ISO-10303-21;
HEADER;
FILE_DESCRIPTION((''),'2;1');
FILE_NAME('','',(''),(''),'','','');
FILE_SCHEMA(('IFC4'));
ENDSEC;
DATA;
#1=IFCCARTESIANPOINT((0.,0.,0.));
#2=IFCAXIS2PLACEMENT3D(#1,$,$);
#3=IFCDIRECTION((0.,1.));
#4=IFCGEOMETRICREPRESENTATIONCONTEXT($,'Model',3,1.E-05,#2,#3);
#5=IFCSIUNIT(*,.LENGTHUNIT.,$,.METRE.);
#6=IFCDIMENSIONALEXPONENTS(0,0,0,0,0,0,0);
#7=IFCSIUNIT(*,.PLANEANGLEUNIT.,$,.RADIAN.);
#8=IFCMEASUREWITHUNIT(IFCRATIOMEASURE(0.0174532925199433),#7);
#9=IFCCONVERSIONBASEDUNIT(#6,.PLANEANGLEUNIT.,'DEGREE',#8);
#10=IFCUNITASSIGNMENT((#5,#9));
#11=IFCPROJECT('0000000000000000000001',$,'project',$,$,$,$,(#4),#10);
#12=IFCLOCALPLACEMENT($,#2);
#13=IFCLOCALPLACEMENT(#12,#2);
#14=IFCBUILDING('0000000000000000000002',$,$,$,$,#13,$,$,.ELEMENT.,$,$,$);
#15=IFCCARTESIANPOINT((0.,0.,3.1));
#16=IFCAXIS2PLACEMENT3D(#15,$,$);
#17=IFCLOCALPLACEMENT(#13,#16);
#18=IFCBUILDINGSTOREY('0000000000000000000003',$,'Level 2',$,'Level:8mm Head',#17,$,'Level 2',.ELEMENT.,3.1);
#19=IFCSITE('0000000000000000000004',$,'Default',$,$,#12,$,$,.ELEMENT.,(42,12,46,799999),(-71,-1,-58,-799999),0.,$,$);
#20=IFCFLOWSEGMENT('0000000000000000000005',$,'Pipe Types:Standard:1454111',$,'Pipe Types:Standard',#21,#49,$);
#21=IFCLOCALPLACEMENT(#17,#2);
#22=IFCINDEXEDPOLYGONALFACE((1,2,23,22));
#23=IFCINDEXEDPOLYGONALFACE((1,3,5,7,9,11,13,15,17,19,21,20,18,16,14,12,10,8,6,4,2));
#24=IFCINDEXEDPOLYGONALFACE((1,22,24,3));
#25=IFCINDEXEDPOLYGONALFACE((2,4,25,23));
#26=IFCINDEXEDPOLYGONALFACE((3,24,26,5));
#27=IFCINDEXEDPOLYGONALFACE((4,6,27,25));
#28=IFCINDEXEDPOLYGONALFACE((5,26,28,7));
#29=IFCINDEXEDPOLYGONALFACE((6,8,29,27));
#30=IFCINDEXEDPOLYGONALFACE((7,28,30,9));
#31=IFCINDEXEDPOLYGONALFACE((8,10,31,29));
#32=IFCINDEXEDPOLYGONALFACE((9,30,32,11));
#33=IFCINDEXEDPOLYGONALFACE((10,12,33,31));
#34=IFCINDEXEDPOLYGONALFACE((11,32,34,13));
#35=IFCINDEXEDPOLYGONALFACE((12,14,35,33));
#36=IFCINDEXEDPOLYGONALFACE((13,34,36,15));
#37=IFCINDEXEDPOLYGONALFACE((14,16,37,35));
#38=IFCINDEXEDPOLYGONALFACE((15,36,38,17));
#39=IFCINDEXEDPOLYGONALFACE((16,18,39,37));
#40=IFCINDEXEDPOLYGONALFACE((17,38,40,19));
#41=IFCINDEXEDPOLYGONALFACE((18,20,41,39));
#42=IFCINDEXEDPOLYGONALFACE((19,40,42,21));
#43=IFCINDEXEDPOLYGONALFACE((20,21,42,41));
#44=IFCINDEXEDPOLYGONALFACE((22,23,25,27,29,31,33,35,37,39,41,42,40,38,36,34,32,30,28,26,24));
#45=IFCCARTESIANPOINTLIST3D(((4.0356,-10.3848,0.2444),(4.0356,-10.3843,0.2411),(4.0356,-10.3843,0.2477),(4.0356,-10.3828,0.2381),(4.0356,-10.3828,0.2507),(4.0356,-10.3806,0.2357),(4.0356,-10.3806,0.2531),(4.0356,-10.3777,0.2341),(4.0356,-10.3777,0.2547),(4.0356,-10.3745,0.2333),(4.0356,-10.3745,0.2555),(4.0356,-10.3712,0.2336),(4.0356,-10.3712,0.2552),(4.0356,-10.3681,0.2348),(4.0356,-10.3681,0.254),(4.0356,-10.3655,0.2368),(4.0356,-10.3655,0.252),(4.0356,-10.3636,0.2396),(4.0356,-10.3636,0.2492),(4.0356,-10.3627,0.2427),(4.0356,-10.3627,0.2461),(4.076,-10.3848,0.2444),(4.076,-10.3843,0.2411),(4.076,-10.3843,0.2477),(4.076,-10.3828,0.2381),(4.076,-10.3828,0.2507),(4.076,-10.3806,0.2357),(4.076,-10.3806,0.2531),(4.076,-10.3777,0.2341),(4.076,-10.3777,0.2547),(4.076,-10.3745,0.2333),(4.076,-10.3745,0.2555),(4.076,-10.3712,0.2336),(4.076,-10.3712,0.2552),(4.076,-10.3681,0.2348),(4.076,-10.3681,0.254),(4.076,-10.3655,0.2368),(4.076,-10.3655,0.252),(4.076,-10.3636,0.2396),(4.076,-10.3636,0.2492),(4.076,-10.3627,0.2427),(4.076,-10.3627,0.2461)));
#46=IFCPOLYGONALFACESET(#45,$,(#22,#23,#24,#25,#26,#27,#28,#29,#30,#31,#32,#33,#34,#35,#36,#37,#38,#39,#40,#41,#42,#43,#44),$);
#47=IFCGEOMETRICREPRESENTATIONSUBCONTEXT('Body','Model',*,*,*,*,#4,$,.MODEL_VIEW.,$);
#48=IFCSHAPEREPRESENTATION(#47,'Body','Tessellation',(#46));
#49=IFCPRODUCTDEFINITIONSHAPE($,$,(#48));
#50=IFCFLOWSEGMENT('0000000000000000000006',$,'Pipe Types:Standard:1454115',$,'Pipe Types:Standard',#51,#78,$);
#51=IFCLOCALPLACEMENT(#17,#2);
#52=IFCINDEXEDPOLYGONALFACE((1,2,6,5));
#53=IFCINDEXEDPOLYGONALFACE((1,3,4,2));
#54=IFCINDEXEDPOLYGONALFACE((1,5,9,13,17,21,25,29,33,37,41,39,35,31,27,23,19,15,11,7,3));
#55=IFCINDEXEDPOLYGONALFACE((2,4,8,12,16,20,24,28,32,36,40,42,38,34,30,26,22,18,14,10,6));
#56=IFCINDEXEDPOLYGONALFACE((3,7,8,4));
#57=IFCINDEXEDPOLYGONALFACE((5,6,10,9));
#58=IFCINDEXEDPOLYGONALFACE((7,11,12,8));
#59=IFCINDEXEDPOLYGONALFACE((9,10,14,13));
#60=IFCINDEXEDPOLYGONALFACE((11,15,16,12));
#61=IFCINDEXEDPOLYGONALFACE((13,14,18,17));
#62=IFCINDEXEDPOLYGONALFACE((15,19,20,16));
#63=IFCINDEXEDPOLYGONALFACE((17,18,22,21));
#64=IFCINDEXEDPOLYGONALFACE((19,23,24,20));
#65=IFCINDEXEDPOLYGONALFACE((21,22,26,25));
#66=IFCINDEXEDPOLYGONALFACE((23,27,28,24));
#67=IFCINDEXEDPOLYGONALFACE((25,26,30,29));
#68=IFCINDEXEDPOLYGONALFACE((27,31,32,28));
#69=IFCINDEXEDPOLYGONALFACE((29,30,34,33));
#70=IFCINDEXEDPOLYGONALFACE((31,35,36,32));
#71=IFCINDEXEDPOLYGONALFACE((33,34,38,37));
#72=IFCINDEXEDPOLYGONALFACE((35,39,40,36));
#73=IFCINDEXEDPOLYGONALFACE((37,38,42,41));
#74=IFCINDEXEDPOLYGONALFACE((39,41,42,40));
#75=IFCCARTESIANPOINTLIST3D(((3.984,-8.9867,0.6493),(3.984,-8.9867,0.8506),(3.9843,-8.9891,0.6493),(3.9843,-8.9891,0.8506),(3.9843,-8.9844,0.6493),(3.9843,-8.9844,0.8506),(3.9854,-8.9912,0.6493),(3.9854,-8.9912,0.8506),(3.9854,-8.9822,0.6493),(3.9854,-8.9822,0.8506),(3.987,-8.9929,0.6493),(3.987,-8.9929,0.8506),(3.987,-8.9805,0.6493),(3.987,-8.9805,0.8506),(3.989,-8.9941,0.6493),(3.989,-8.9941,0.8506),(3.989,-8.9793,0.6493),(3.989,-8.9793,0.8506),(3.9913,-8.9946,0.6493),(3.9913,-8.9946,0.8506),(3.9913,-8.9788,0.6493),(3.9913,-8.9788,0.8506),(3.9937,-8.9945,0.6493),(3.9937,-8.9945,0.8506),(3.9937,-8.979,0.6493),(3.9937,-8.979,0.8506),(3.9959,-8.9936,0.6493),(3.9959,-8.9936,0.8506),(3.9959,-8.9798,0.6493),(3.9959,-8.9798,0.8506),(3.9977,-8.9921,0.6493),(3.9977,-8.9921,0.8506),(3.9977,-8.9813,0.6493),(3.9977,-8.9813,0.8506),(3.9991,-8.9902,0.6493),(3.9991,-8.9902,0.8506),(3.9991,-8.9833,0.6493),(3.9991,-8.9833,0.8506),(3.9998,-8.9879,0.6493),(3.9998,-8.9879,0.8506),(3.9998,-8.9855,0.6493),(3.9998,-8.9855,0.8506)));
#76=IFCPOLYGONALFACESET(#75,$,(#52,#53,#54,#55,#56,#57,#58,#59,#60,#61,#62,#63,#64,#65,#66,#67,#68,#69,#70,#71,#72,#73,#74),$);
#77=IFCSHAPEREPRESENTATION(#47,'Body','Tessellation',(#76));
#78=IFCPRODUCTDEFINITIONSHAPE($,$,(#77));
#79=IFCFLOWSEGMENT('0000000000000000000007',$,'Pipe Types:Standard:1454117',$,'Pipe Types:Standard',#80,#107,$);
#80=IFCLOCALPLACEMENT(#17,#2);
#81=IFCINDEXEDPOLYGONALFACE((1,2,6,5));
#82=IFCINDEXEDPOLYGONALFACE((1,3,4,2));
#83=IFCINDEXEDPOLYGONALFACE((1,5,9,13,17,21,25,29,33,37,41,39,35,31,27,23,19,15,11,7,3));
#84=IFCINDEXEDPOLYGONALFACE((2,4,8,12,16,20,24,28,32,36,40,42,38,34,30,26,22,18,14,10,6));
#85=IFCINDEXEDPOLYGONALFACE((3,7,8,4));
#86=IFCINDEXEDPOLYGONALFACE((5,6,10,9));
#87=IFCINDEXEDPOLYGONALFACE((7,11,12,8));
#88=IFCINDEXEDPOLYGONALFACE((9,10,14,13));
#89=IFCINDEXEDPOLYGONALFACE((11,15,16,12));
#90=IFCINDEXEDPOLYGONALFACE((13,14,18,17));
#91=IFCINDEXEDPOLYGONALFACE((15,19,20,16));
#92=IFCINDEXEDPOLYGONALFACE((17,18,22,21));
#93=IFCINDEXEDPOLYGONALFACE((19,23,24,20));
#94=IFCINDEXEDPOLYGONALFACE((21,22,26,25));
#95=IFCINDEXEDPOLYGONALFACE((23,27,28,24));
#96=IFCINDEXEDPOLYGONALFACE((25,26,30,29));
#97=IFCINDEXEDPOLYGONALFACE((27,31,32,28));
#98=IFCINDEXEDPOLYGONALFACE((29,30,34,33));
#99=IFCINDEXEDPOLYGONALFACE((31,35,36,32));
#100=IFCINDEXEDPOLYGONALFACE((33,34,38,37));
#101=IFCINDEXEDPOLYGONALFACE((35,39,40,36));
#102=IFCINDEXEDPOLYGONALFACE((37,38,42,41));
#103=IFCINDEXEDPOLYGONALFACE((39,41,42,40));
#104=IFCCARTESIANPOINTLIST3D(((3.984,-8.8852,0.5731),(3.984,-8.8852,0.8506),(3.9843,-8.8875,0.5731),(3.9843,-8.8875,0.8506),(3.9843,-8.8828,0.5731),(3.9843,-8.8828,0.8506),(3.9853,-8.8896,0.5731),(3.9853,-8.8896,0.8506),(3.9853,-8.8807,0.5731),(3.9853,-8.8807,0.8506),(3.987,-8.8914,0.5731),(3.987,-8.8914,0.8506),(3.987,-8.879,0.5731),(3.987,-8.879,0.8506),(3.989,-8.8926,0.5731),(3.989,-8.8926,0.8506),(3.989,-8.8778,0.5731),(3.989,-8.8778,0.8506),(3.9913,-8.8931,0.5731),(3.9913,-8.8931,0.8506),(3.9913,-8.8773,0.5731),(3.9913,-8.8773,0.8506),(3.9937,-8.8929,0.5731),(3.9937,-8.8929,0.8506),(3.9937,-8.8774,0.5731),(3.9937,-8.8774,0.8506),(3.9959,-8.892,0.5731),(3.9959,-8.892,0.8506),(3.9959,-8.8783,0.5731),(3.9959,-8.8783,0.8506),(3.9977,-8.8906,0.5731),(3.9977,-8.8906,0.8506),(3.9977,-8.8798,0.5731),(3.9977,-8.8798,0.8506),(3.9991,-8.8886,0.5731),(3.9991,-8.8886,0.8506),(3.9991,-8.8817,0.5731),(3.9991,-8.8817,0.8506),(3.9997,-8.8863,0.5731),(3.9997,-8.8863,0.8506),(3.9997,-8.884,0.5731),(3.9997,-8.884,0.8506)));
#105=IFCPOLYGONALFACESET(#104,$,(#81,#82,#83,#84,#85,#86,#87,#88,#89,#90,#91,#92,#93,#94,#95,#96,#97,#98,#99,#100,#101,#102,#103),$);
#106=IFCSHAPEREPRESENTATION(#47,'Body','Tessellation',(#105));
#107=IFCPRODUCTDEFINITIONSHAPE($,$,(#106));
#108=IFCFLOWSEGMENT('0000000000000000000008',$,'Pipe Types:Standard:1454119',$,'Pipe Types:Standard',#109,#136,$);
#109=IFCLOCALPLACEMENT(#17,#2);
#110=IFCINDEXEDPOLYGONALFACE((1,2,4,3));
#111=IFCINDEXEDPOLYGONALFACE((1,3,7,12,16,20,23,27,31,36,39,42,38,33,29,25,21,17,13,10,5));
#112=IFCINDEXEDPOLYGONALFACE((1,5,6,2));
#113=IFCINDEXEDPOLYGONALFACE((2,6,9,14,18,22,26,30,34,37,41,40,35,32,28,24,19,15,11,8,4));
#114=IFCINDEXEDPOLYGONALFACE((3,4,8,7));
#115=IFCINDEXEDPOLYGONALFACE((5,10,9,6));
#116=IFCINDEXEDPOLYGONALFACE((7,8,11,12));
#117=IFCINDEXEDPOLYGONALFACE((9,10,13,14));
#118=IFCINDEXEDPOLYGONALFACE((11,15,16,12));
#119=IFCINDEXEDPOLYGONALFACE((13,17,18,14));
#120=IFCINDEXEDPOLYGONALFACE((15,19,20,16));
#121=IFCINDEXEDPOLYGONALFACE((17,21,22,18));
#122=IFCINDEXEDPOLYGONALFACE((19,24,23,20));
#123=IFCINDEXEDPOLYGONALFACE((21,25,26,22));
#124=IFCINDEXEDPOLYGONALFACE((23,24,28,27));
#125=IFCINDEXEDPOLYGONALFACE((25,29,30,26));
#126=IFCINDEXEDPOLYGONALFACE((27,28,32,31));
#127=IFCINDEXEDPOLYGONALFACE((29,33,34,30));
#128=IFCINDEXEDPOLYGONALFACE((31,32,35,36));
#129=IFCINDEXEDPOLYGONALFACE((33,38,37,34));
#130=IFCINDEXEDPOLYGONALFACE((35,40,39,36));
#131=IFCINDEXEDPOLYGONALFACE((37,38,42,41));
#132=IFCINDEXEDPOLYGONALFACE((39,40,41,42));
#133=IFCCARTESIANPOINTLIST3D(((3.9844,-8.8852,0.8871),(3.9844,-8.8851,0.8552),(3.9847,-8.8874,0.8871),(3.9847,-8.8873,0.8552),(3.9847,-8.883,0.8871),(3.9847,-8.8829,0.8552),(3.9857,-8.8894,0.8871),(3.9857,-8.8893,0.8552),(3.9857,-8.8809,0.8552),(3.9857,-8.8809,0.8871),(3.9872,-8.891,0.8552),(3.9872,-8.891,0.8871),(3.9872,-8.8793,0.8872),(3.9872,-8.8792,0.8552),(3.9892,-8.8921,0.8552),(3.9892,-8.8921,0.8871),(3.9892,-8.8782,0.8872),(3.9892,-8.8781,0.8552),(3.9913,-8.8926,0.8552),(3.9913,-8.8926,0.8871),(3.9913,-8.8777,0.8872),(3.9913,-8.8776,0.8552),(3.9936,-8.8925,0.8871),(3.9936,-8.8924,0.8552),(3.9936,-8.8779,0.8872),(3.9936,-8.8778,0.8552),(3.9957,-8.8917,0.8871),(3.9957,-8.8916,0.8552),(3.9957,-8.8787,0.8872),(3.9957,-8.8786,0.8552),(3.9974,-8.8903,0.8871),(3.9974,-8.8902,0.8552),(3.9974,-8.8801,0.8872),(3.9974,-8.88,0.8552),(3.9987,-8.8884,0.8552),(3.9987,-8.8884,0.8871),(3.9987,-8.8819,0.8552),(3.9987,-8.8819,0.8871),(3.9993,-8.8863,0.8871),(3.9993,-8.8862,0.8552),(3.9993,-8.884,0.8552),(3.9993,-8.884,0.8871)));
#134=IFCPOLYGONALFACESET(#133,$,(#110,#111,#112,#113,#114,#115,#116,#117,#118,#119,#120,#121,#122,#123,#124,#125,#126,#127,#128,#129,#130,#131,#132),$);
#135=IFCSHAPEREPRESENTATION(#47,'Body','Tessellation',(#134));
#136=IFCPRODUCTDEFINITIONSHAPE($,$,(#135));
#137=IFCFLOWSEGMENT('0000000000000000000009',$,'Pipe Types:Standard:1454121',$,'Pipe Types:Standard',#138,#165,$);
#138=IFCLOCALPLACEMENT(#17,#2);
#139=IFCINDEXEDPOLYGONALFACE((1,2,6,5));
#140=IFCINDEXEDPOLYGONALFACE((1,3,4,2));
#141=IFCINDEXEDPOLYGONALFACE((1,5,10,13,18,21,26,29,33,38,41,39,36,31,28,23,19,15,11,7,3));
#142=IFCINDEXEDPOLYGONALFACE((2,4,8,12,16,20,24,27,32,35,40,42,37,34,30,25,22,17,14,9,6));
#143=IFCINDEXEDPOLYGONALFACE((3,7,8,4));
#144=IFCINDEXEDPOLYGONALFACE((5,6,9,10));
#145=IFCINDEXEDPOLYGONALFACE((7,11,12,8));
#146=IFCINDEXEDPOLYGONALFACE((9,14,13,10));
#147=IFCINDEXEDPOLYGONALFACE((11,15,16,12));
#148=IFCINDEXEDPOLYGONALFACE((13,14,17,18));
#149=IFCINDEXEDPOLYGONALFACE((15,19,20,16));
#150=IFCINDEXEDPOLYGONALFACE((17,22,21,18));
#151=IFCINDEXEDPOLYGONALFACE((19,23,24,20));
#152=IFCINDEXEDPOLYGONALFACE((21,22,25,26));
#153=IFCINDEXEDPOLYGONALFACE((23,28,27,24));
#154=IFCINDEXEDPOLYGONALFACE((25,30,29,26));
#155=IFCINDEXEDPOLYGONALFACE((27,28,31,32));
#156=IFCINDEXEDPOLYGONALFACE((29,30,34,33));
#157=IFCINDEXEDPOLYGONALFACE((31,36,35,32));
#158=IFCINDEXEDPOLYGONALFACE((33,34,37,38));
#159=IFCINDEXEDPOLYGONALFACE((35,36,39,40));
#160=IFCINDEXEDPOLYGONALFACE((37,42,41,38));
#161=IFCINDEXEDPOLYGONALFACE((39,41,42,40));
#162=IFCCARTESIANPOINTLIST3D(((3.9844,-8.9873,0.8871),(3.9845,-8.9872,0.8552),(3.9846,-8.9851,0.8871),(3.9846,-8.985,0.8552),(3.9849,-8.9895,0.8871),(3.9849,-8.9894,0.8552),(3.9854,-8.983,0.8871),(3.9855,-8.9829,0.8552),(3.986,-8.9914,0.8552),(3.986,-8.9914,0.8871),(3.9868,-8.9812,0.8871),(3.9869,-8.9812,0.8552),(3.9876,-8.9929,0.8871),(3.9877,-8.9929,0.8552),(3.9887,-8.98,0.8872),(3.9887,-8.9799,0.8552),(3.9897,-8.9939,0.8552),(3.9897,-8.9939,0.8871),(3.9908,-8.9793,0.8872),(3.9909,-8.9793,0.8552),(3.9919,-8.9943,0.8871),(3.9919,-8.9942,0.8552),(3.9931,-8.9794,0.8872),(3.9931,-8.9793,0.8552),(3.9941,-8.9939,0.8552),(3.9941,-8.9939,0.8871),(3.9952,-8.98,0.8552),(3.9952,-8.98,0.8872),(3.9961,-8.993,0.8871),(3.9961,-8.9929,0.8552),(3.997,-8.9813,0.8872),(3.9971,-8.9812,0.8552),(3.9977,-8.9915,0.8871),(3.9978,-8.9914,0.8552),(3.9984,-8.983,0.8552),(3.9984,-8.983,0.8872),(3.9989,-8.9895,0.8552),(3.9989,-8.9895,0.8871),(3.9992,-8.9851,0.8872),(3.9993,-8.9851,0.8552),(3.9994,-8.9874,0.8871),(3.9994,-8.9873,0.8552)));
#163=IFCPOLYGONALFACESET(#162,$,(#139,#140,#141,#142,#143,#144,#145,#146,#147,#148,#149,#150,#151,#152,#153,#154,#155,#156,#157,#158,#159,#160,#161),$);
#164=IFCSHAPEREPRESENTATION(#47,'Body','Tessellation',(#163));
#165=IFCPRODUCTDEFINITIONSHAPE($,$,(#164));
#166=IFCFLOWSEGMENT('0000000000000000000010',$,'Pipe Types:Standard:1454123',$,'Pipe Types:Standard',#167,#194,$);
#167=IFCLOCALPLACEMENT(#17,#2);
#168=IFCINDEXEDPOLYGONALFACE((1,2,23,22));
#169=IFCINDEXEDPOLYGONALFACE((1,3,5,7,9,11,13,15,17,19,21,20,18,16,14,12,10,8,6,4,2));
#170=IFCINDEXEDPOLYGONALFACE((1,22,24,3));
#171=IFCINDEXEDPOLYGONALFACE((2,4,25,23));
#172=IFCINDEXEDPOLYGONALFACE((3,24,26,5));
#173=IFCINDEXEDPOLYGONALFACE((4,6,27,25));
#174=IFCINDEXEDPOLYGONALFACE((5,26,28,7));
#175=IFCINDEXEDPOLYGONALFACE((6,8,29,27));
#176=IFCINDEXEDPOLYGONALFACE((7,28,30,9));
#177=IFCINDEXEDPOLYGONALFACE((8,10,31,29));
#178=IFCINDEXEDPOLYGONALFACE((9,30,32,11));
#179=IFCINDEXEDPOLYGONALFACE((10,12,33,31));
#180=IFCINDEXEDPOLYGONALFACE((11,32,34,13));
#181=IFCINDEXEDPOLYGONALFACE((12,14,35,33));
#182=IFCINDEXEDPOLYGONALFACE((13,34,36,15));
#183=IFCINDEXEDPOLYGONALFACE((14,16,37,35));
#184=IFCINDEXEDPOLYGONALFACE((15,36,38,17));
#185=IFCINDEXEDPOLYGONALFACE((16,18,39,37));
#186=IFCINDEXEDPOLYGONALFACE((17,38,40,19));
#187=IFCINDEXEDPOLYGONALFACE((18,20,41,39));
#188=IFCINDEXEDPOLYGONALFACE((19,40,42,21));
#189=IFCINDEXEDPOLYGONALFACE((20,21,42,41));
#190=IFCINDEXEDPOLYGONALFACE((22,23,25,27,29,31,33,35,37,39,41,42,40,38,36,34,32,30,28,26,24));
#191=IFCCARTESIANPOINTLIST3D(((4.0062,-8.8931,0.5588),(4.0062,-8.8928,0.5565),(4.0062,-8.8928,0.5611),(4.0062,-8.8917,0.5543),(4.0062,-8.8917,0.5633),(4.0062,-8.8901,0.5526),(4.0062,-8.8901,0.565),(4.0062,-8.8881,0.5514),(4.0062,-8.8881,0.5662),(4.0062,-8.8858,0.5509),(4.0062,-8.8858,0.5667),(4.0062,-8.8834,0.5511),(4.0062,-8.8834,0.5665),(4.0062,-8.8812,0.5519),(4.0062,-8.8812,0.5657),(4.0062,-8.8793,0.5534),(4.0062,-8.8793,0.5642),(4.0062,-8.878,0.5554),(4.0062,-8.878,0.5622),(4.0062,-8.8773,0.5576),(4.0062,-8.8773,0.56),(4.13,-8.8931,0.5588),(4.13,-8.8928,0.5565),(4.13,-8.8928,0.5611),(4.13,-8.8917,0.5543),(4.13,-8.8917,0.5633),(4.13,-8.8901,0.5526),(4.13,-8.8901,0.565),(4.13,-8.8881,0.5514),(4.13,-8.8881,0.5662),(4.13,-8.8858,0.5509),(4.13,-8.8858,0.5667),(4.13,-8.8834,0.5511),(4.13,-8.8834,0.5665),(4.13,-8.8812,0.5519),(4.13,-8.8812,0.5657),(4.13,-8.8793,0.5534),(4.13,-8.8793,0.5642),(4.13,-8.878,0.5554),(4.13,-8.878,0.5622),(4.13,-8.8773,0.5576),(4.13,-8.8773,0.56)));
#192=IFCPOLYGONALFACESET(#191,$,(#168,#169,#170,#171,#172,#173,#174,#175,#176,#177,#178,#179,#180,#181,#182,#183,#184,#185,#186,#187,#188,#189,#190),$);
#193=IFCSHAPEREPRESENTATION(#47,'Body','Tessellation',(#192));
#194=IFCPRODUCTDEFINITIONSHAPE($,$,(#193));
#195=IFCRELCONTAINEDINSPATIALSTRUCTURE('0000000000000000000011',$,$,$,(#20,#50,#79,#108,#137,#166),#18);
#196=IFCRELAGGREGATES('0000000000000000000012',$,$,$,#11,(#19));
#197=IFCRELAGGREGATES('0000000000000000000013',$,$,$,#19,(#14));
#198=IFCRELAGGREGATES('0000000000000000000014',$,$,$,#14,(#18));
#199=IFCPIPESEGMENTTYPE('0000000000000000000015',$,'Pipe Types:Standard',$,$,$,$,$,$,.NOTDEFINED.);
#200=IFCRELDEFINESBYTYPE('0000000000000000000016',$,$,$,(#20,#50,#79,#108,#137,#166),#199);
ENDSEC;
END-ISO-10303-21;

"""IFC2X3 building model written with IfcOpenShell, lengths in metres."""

from ifc_helpers import new_model, entity, si_unit, converted_unit, direction, frame, frame_2d, origin, origin_2d_with_axis, place, context, subcontext, project, spatial, circle, extrude, type_object, element, save


model = new_model("IFC2X3")

# Units and contexts
model_context = context("Model", 3, precision=1e-05, world=origin(), true_north=direction((0.0, 1.0)))
body_context = subcontext(model_context, "Body", "Model", "MODEL_VIEW")
ifc_project = project(units=[si_unit("LENGTHUNIT", "METRE"), converted_unit("PLANEANGLEUNIT", "DEGREE", entity("IfcRatioMeasure", 0.0174532925199433), si_unit("PLANEANGLEUNIT", "RADIAN"), dimensions=[0, 0, 0, 0, 0, 0, 0])], contexts=[model_context])

# Site, building, storey
site_placement = place(None, origin())
site = spatial("IfcSite", under=ifc_project, at=site_placement, Name="Default", CompositionType="ELEMENT", RefLatitude=(42, 12, 46, 799999), RefLongitude=(-71, -1, -58, -799999), RefElevation=0.0)
building_placement = place(site_placement, origin())
building = spatial("IfcBuilding", under=site, at=building_placement, CompositionType="ELEMENT")
storey_placement = place(building_placement, frame((0.0, 0.0, 3.1)))
storey = spatial("IfcBuildingStorey", under=building, at=storey_placement, Name="Level 2", ObjectType="Level:8mm Head", LongName="Level 2", CompositionType="ELEMENT", Elevation=3.1)

# Flow segments
pipe_segment_type = type_object("IfcPipeSegmentType", Name="Pipe Types:Standard", PredefinedType="NOTDEFINED")
flow_segment_1_placement = place(storey_placement, origin())
element("IfcFlowSegment", 1, at=flow_segment_1_placement, inside=storey, type_object=pipe_segment_type, Name="Pipe Types:Standard:1454111", ObjectType="Pipe Types:Standard", context=body_context, shape_type="SweptSolid", body=[
    extrude(circle(Radius=0.0111, at=origin_2d_with_axis()), frame((4.0356, -10.3737, 0.2444), z_axis=(1.0, 0.0, 0.0), x_axis=(0.0, -1.0, 0.0)), (0.0, 0.0, 1.0), 0.0405),
])
flow_segment_2_placement = place(storey_placement, origin())
element("IfcFlowSegment", 2, at=flow_segment_2_placement, inside=storey, type_object=pipe_segment_type, Name="Pipe Types:Standard:1454115", ObjectType="Pipe Types:Standard", context=body_context, shape_type="SweptSolid", body=[
    extrude(circle(Radius=0.0079, at=frame_2d((0.0, 0.0), x_axis=(1.0, 0.0))), frame((3.9919, -8.9867, 0.6493), z_axis=(0.0, 0.0, 1.0), x_axis=(-1.0, 0.0, 0.0)), (0.0, 0.0, 1.0), 0.2013),
])
flow_segment_3_placement = place(storey_placement, origin())
element("IfcFlowSegment", 3, at=flow_segment_3_placement, inside=storey, type_object=pipe_segment_type, Name="Pipe Types:Standard:1454117", ObjectType="Pipe Types:Standard", context=body_context, shape_type="SweptSolid", body=[
    extrude(circle(Radius=0.0079, at=origin_2d_with_axis()), frame((3.9919, -8.8852, 0.5731), z_axis=(0.0, 0.0, 1.0), x_axis=(-1.0, 0.0, 0.0)), (0.0, 0.0, 1.0), 0.2775),
])
flow_segment_4_placement = place(storey_placement, origin())
element("IfcFlowSegment", 4, at=flow_segment_4_placement, inside=storey, type_object=pipe_segment_type, Name="Pipe Types:Standard:1454119", ObjectType="Pipe Types:Standard", context=body_context, shape_type="SweptSolid", body=[
    extrude(circle(Radius=0.0075, at=frame_2d((0.0, 0.0), x_axis=(1.0, 0.0))), frame((3.9919, -8.8851, 0.8552), z_axis=(0.0, -0.001852, 0.999998), x_axis=(-1.0, 0.0, 0.0)), (0.0, 0.0, 1.0), 0.032),
])
flow_segment_5_placement = place(storey_placement, origin())
element("IfcFlowSegment", 5, at=flow_segment_5_placement, inside=storey, type_object=pipe_segment_type, Name="Pipe Types:Standard:1454121", ObjectType="Pipe Types:Standard", context=body_context, shape_type="SweptSolid", body=[
    extrude(circle(Radius=0.0075, at=frame_2d((0.0, 0.0), x_axis=(1.0, 0.0))), frame((3.9919, -8.9867, 0.8552), z_axis=(-0.001081, -0.001852, 0.999998), x_axis=(-0.863538, 0.504283, 0.0)), (0.0, 0.0, 1.0), 0.032),
])
flow_segment_6_placement = place(storey_placement, origin())
element("IfcFlowSegment", 6, at=flow_segment_6_placement, inside=storey, type_object=pipe_segment_type, Name="Pipe Types:Standard:1454123", ObjectType="Pipe Types:Standard", context=body_context, shape_type="SweptSolid", body=[
    extrude(circle(Radius=0.0079, at=origin_2d_with_axis()), frame((4.0062, -8.8852, 0.5588), z_axis=(1.0, 0.0, 0.0), x_axis=(0.0, -1.0, 0.0)), (0.0, 0.0, 1.0), 0.1238),
])

save(model, "model.ifc")
